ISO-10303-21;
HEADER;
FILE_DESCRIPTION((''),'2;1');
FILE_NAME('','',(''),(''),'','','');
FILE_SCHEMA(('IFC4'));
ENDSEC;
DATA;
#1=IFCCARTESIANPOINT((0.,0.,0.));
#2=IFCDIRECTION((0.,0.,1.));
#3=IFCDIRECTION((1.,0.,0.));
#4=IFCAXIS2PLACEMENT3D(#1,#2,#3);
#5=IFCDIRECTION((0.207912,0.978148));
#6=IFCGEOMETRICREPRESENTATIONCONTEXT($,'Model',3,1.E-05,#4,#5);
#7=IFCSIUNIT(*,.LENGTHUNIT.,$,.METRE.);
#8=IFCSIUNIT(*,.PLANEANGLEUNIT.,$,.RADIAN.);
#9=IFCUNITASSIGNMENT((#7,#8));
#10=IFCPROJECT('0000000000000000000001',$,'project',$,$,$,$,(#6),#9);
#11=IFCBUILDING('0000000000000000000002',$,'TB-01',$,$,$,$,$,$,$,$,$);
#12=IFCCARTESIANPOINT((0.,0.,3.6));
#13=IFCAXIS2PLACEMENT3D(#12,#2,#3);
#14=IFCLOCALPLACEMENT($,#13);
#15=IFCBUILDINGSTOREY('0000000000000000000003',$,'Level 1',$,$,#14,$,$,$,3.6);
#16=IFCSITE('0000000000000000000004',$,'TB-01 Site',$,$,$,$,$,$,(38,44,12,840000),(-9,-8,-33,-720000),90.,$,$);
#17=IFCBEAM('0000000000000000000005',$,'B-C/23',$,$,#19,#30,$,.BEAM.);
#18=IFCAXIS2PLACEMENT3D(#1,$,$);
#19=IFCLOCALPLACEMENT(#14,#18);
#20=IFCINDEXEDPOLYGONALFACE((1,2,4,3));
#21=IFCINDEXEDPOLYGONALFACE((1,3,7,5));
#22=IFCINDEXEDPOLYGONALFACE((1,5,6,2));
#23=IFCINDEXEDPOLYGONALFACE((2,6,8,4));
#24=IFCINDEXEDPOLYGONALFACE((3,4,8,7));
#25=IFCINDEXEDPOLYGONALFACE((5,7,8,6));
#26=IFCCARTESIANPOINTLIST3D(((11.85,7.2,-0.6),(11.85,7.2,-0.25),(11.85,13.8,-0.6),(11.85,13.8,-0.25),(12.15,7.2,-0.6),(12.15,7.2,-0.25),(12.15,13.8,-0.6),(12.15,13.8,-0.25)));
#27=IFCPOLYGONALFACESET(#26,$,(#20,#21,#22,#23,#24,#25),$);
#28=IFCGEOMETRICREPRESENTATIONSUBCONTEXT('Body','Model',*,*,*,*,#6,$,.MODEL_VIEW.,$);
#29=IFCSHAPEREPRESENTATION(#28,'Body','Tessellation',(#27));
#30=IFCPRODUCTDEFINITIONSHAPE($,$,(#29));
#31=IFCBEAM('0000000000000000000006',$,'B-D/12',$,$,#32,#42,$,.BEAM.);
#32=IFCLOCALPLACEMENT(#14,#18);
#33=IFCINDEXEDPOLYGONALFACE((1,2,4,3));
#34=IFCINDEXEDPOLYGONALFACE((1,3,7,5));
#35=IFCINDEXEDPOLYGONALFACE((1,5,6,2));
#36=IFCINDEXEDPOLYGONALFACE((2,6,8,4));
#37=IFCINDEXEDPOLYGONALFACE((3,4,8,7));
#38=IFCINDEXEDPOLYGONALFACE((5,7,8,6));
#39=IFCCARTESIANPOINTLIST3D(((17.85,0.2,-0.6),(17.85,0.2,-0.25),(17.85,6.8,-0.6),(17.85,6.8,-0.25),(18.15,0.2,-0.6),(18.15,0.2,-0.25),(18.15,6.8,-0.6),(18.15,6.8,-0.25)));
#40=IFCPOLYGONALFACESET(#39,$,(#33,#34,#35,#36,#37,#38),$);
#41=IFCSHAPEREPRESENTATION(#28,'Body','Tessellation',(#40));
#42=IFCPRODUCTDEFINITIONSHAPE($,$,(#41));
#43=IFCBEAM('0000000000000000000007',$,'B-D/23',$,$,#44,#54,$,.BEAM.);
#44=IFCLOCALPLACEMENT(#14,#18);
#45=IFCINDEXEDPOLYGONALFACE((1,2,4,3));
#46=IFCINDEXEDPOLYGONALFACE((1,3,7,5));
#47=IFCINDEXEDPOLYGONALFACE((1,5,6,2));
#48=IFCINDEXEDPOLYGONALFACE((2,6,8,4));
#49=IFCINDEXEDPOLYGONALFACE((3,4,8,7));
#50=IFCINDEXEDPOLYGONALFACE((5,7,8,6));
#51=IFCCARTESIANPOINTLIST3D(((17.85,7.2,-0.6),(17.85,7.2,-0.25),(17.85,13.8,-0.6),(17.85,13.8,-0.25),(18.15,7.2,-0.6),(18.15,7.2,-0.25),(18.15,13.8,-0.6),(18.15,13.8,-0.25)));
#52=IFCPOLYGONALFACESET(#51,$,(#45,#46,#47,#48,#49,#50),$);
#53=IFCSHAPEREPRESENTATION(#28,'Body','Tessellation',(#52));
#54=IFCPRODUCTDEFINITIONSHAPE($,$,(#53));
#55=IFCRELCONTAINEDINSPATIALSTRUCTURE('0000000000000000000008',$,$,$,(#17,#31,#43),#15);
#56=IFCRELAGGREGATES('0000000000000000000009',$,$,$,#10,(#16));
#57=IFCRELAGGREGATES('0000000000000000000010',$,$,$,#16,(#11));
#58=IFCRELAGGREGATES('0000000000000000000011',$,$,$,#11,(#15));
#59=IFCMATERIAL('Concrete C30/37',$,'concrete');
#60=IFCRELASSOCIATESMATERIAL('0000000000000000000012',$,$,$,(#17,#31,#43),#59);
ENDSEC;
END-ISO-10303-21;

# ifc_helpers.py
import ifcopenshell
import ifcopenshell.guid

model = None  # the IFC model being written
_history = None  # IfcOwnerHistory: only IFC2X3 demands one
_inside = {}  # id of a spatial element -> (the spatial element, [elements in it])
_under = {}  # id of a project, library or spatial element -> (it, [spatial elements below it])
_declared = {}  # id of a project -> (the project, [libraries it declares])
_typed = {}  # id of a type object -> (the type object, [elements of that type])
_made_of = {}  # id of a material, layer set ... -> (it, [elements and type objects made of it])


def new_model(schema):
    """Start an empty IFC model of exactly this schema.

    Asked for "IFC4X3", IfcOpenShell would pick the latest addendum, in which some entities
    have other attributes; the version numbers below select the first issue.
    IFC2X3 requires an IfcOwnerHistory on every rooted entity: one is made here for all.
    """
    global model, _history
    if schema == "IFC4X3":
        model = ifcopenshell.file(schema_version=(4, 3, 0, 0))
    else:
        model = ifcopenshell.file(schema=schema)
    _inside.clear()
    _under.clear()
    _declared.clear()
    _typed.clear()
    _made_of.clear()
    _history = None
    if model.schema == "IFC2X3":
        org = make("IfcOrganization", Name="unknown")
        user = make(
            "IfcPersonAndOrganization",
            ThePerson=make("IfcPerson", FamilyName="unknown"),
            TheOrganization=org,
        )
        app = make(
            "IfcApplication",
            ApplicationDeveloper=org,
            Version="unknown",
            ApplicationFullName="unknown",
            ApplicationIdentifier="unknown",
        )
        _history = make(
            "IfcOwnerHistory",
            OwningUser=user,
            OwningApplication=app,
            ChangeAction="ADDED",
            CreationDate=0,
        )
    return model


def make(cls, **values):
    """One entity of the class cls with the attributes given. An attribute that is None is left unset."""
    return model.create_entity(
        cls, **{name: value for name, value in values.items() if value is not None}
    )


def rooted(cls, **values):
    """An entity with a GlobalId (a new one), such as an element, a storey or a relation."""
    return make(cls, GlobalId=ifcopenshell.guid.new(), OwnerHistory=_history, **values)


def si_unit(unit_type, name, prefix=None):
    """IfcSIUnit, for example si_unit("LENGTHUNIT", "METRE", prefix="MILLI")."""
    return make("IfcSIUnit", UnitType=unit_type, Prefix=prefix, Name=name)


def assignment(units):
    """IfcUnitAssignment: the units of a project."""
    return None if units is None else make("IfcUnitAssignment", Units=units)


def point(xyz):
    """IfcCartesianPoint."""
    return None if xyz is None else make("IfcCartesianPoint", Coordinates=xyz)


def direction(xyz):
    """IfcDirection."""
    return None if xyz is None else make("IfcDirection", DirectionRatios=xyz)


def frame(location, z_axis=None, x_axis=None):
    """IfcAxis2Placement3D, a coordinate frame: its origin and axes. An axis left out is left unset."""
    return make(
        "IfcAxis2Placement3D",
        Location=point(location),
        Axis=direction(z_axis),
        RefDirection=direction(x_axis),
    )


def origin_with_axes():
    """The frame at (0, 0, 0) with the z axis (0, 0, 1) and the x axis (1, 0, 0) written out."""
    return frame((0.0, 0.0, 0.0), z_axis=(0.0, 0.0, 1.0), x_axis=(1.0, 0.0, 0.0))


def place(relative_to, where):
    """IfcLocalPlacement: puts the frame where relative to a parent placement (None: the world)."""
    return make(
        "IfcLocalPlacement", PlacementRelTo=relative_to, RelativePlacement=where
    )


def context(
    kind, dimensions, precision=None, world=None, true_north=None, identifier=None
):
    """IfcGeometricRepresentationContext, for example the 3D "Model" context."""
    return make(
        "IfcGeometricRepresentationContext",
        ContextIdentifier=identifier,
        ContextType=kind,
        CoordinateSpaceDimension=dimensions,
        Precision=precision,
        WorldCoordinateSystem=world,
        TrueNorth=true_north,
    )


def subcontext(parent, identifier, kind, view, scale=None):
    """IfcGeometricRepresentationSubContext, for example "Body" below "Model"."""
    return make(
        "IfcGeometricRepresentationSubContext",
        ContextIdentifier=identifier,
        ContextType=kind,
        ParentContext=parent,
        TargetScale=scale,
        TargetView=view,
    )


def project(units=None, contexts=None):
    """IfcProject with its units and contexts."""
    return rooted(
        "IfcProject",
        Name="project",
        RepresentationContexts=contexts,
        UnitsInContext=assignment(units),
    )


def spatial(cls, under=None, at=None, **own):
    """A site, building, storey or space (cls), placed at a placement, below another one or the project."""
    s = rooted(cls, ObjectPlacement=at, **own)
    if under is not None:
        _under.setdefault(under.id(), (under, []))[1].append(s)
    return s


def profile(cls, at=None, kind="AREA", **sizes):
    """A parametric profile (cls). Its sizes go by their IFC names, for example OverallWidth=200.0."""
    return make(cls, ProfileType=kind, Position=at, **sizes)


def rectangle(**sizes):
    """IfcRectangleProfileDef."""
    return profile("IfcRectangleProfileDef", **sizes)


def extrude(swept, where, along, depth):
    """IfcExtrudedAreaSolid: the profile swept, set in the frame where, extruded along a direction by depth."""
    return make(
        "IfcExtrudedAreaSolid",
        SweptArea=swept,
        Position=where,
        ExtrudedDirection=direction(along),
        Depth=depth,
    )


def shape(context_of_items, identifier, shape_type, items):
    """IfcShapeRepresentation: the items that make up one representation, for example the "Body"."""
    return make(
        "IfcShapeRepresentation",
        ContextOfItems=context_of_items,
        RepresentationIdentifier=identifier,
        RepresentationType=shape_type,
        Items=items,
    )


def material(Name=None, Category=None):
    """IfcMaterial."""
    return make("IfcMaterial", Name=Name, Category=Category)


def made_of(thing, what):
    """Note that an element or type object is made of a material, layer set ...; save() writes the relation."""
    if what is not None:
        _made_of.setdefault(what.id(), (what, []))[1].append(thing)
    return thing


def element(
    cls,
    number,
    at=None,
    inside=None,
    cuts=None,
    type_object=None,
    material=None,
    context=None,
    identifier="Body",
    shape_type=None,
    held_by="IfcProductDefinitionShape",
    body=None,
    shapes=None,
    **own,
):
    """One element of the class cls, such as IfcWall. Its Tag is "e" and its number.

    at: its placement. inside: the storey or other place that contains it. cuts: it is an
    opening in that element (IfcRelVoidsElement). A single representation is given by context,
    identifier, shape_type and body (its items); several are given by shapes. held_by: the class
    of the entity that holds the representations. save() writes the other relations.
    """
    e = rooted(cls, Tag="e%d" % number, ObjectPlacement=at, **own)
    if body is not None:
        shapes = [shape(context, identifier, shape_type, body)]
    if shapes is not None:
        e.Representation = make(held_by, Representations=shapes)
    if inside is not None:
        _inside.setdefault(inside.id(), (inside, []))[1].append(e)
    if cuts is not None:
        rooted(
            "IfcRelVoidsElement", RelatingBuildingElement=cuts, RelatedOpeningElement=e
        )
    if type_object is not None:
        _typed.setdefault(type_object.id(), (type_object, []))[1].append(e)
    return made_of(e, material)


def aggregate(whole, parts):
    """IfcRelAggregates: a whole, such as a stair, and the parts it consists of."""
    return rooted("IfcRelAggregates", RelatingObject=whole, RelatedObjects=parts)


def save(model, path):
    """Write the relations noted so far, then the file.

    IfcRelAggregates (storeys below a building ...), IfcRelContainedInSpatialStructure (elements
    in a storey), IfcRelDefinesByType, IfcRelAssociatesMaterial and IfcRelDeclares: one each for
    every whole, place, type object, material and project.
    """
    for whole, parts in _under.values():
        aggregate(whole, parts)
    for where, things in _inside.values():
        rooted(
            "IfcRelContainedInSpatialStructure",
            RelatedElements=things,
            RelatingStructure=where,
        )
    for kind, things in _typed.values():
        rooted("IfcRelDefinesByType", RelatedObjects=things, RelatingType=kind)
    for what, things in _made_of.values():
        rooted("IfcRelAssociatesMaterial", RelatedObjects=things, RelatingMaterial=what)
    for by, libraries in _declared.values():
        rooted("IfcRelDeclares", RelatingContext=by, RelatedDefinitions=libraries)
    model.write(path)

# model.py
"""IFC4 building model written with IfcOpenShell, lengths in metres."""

from ifc_helpers import new_model, si_unit, direction, frame, origin_with_axes, place, context, subcontext, project, spatial, rectangle, extrude, material, element, save


model = new_model("IFC4")

# Units and contexts
model_context = context("Model", 3, precision=1e-05, world=origin_with_axes(), true_north=direction((0.207912, 0.978148)))
body_context = subcontext(model_context, "Body", "Model", "MODEL_VIEW")
ifc_project = project(units=[si_unit("LENGTHUNIT", "METRE"), si_unit("PLANEANGLEUNIT", "RADIAN")], contexts=[model_context])

# Site, building, storey
site = spatial("IfcSite", under=ifc_project, Name="TB-01 Site", RefLatitude=(38, 44, 12, 840000), RefLongitude=(-9, -8, -33, -720000), RefElevation=90.0)
building = spatial("IfcBuilding", under=site, Name="TB-01")
storey_placement = place(None, frame((0.0, 0.0, 3.6), z_axis=(0.0, 0.0, 1.0), x_axis=(1.0, 0.0, 0.0)))
storey = spatial("IfcBuildingStorey", under=building, at=storey_placement, Name="Level 1", Elevation=3.6)

# Shared definitions
ifc_material = material(Name="Concrete C30/37", Category="concrete")

# Beams
beam_1_placement = place(storey_placement, frame((12.0, 7.2, -0.425), z_axis=(0.0, 1.0, 0.0), x_axis=(-1.0, 0.0, 0.0)))
element("IfcBeam", 1, at=beam_1_placement, inside=storey, material=ifc_material, Name="B-C/23", PredefinedType="BEAM", context=body_context, shape_type="SweptSolid", body=[
    extrude(rectangle(XDim=0.3, YDim=0.35), origin_with_axes(), (0.0, 0.0, 1.0), 6.6),
])
beam_2_placement = place(storey_placement, frame((18.0, 0.2, -0.425), z_axis=(0.0, 1.0, 0.0), x_axis=(-1.0, 0.0, 0.0)))
element("IfcBeam", 2, at=beam_2_placement, inside=storey, material=ifc_material, Name="B-D/12", PredefinedType="BEAM", context=body_context, shape_type="SweptSolid", body=[
    extrude(rectangle(XDim=0.3, YDim=0.35), origin_with_axes(), (0.0, 0.0, 1.0), 6.6),
])
beam_3_placement = place(storey_placement, frame((18.0, 7.2, -0.425), z_axis=(0.0, 1.0, 0.0), x_axis=(-1.0, 0.0, 0.0)))
element("IfcBeam", 3, at=beam_3_placement, inside=storey, material=ifc_material, Name="B-D/23", PredefinedType="BEAM", context=body_context, shape_type="SweptSolid", body=[
    extrude(rectangle(XDim=0.3, YDim=0.35), origin_with_axes(), (0.0, 0.0, 1.0), 6.6),
])

save(model, "model.ifc")
